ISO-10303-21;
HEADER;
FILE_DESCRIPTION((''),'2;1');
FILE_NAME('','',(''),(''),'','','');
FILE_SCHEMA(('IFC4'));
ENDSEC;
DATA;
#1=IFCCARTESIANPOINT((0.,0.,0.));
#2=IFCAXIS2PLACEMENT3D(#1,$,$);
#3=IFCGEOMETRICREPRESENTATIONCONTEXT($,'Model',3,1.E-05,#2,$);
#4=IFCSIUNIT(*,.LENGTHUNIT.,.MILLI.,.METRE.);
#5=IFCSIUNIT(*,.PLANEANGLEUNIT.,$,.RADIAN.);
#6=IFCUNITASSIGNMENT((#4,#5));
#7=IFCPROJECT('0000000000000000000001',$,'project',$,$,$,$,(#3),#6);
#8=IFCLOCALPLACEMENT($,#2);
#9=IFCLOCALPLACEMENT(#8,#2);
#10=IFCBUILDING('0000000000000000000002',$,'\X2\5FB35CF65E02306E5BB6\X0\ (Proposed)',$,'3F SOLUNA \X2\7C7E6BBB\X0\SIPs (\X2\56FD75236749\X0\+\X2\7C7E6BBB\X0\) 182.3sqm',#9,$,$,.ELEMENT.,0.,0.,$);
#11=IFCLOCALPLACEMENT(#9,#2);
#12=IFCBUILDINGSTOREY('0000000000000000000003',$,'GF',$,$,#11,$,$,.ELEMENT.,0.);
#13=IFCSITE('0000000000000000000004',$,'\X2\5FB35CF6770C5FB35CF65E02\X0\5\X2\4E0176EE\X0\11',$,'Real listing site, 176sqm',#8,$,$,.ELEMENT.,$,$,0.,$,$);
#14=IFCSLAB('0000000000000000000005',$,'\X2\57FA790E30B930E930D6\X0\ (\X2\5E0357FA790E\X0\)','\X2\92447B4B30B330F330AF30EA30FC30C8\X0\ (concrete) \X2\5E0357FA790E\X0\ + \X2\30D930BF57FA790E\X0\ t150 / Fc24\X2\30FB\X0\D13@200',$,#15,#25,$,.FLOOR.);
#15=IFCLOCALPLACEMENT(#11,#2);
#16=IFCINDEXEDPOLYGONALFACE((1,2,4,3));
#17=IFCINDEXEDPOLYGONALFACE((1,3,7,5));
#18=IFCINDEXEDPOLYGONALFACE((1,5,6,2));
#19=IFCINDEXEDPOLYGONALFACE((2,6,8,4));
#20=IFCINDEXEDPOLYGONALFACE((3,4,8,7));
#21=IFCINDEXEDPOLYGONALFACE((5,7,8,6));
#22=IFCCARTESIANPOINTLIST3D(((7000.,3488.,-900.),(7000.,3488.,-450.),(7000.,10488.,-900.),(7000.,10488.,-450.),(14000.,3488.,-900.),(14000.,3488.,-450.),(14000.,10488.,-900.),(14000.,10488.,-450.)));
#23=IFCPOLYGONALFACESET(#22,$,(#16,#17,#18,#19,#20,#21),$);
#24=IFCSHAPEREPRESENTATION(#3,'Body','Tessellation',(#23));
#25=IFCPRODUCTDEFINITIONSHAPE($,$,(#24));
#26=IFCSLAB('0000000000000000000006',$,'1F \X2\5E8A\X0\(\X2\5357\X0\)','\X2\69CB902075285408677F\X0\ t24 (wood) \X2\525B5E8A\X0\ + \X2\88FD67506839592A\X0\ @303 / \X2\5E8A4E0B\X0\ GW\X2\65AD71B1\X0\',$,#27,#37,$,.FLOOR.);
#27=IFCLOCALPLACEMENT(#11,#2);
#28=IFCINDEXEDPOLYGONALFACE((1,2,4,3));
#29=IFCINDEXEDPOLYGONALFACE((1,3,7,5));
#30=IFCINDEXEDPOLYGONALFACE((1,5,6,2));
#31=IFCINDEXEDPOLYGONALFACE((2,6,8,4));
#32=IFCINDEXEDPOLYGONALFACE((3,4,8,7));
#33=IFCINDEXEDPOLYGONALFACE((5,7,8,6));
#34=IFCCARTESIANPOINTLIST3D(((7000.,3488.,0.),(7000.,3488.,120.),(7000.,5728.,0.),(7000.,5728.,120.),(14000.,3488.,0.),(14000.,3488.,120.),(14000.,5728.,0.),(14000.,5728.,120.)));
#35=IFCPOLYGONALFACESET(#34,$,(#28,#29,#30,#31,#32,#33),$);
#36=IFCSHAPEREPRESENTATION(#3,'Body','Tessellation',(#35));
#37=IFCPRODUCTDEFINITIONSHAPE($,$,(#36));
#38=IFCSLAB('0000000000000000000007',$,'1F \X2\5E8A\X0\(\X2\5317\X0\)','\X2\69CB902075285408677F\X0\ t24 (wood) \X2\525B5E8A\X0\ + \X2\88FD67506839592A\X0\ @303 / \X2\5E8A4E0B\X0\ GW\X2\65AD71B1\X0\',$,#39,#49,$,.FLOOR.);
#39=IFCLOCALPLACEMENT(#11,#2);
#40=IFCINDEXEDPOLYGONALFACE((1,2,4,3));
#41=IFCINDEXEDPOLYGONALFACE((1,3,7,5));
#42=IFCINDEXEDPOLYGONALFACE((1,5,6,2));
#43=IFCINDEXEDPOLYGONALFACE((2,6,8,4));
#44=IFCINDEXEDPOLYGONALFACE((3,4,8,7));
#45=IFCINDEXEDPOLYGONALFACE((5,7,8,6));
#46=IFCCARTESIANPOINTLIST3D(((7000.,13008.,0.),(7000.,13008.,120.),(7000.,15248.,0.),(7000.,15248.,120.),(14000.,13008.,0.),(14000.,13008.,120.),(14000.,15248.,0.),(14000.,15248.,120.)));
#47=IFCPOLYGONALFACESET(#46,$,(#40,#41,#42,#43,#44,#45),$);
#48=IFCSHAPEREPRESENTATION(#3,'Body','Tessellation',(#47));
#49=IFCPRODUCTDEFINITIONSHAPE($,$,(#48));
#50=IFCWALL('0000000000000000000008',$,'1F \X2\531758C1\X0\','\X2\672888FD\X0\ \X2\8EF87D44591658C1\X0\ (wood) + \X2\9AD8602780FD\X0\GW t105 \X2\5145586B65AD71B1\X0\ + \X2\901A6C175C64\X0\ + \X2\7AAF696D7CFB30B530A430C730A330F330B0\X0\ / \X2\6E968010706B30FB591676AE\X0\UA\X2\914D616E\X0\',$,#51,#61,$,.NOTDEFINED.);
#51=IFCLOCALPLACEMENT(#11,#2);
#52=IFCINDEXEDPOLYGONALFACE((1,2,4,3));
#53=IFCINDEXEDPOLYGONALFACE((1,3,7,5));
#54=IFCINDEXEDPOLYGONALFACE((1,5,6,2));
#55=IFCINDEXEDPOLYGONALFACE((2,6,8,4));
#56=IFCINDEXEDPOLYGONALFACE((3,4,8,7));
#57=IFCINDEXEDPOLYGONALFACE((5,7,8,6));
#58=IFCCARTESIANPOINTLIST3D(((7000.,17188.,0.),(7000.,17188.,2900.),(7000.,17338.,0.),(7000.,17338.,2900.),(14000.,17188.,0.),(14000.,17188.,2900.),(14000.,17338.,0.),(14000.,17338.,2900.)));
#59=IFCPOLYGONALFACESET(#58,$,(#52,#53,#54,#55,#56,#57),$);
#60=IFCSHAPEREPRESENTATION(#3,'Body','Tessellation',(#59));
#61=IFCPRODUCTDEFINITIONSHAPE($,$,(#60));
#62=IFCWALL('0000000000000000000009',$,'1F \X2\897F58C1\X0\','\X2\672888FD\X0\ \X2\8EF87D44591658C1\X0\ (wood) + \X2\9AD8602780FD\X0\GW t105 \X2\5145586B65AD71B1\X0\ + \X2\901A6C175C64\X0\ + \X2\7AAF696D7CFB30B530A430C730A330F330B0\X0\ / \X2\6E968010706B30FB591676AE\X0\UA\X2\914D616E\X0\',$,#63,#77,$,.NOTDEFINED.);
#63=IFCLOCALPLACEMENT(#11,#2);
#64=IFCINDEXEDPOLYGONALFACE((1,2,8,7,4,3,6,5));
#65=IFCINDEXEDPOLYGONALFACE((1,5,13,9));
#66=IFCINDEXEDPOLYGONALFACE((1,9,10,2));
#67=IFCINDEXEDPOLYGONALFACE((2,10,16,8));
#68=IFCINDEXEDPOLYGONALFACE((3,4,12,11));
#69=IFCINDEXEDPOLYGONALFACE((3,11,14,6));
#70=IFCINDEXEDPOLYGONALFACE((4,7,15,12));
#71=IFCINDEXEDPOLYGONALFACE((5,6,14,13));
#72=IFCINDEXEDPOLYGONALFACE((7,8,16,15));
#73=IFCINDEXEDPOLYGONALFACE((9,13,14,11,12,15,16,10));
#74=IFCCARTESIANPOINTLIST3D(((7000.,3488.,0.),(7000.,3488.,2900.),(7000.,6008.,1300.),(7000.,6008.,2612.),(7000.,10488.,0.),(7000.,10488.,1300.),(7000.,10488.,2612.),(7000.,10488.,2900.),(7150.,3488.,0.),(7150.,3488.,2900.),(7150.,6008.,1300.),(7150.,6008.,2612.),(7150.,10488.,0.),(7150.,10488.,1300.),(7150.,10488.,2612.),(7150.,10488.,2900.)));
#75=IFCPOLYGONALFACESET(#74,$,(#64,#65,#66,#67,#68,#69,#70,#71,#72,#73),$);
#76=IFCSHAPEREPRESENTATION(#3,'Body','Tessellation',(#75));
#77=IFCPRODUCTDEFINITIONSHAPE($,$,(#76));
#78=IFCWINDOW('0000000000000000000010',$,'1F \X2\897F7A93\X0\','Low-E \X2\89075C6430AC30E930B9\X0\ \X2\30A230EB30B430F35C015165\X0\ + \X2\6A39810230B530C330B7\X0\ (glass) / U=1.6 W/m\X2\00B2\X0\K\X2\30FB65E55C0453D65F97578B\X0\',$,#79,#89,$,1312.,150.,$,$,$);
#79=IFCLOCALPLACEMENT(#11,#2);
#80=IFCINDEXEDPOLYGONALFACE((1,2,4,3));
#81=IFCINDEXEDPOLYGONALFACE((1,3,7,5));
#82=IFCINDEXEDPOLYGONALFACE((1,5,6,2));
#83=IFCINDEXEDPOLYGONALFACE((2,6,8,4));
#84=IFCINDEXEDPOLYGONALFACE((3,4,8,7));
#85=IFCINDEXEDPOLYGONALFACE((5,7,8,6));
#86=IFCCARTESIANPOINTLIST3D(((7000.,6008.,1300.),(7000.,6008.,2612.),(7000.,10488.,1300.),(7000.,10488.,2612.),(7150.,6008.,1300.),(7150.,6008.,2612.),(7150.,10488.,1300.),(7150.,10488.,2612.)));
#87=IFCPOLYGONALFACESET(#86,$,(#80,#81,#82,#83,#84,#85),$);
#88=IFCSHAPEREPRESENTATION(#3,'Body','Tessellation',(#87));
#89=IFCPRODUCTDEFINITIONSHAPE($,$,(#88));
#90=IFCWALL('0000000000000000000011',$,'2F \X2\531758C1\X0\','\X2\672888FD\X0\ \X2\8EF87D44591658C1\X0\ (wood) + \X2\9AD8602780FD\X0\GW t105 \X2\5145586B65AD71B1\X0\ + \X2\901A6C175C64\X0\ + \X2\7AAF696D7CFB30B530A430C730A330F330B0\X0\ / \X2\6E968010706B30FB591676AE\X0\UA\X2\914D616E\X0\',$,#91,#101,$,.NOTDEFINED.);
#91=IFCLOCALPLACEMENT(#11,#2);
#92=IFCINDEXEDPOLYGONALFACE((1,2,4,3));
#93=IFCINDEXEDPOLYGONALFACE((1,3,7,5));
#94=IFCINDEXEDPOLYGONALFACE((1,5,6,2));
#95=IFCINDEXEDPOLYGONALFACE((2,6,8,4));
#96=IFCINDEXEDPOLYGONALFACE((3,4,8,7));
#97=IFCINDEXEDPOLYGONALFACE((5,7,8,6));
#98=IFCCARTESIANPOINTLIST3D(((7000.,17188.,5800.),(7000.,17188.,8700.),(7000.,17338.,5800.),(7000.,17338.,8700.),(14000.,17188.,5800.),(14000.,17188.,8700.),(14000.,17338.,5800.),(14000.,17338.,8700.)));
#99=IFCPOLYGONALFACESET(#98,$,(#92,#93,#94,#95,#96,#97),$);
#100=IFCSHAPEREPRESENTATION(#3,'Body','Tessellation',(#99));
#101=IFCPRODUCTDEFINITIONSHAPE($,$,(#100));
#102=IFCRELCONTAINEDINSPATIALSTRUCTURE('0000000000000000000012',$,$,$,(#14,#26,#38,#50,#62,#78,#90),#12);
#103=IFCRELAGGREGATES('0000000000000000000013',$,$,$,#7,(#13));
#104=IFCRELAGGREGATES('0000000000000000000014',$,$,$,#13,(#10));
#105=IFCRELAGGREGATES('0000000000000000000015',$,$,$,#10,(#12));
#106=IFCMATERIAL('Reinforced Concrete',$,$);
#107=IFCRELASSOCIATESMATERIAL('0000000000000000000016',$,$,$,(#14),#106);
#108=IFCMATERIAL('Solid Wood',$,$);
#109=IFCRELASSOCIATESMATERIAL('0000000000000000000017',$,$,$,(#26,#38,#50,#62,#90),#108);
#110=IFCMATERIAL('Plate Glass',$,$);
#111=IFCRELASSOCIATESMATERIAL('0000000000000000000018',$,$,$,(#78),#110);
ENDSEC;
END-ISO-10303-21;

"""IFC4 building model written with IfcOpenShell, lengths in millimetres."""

from ifc_helpers import new_model, si_unit, frame, frame_2d, origin, place, context, project, spatial, rectangle, extrude, material, element, fill, save


model = new_model("IFC4")

# Units and contexts
model_context = context("Model", 3, precision=1e-05, world=origin())
ifc_project = project(units=[si_unit("LENGTHUNIT", "METRE", prefix="MILLI"), si_unit("PLANEANGLEUNIT", "RADIAN")], contexts=[model_context])

# Site, building, storey
site_placement = place(None, origin())
site = spatial("IfcSite", under=ifc_project, at=site_placement, Name="徳島県徳島市5丁目11", ObjectType="Real listing site, 176sqm", CompositionType="ELEMENT", RefElevation=0.0)
building_placement = place(site_placement, origin())
building = spatial("IfcBuilding", under=site, at=building_placement, Name="徳島市の家 (Proposed)", ObjectType="3F SOLUNA 籾殻SIPs (国産杉+籾殻) 182.3sqm", CompositionType="ELEMENT", ElevationOfRefHeight=0.0, ElevationOfTerrain=0.0)
storey_placement = place(building_placement, origin())
storey = spatial("IfcBuildingStorey", under=building, at=storey_placement, Name="GF", CompositionType="ELEMENT", Elevation=0.0)

# Slabs
ifc_material_1 = material(Name="Reinforced Concrete")
slab_1_placement = place(storey_placement, frame((3500.0, 1744.0, -450.0)))
element("IfcSlab", 1, at=slab_1_placement, inside=storey, material=ifc_material_1, Name="基礎スラブ (布基礎)", Description="鉄筋コンクリート (concrete) 布基礎 + ベタ基礎 t150 / Fc24・D13@200", PredefinedType="FLOOR", context=model_context, shape_type="SweptSolid", body=[
    extrude(rectangle(XDim=7000.0, YDim=7000.0, at=frame_2d((3500.0, 3500.0))), frame((3500.0, 1744.0, -450.0)), (0.0, 0.0, 1.0), 450.0),
])
ifc_material_2 = material(Name="Solid Wood")
slab_2_placement = place(storey_placement, frame((3500.0, 1744.0, 0.0)))
element("IfcSlab", 2, at=slab_2_placement, inside=storey, material=ifc_material_2, Name="1F 床(南)", Description="構造用合板 t24 (wood) 剛床 + 製材根太 @303 / 床下 GW断熱", PredefinedType="FLOOR", context=model_context, shape_type="SweptSolid", body=[
    extrude(rectangle(XDim=7000.0, YDim=2240.0, at=frame_2d((3500.0, 1120.0))), frame((3500.0, 1744.0, 0.0)), (0.0, 0.0, 1.0), 120.0),
])
slab_3_placement = place(storey_placement, frame((3500.0, 6504.0, 0.0)))
element("IfcSlab", 3, at=slab_3_placement, inside=storey, material=ifc_material_2, Name="1F 床(北)", Description="構造用合板 t24 (wood) 剛床 + 製材根太 @303 / 床下 GW断熱", PredefinedType="FLOOR", context=model_context, shape_type="SweptSolid", body=[
    extrude(rectangle(XDim=7000.0, YDim=2240.0, at=frame_2d((3500.0, 1120.0))), frame((3500.0, 6504.0, 0.0)), (0.0, 0.0, 1.0), 120.0),
])

# Shared definitions
ifc_material_3 = material(Name="Plate Glass")

# Wall
wall_1_placement = place(storey_placement, frame((3500.0, 8594.0, 0.0)))
element("IfcWall", 4, at=wall_1_placement, inside=storey, material=ifc_material_2, Name="1F 北壁", Description="木製 軸組外壁 (wood) + 高性能GW t105 充填断熱 + 通気層 + 窯業系サイディング / 準耐火・外皮UA配慮", PredefinedType="NOTDEFINED", context=model_context, shape_type="SweptSolid", body=[
    extrude(rectangle(XDim=7000.0, YDim=150.0, at=frame_2d((3500.0, 75.0))), frame((3500.0, 8594.0, 0.0)), (0.0, 0.0, 1.0), 2900.0),
])

# Wall, opening, window
wall_2_placement = place(storey_placement, frame((3500.0, 1744.0, 0.0)))
wall_2 = element("IfcWall", 5, at=wall_2_placement, inside=storey, material=ifc_material_2, Name="1F 西壁", Description="木製 軸組外壁 (wood) + 高性能GW t105 充填断熱 + 通気層 + 窯業系サイディング / 準耐火・外皮UA配慮", PredefinedType="NOTDEFINED", context=model_context, shape_type="SweptSolid", body=[
    extrude(rectangle(XDim=150.0, YDim=7000.0, at=frame_2d((75.0, 3500.0))), frame((3500.0, 1744.0, 0.0)), (0.0, 0.0, 1.0), 2900.0),
])
opening_1_placement = place(storey_placement, frame((3500.0, 3004.0, 650.0)))
opening_1 = element("IfcOpeningElement", 6, at=opening_1_placement, cuts=wall_2, PredefinedType="NOTDEFINED", context=model_context, shape_type="SweptSolid", body=[
    extrude(rectangle(XDim=150.0, YDim=4480.0, at=frame_2d((75.0, 2240.0))), frame((3500.0, 3004.0, 650.0)), (0.0, 0.0, 1.0), 1312.0),
])
window_1_placement = place(storey_placement, frame((3500.0, 3004.0, 650.0)))
window_1 = element("IfcWindow", 7, at=window_1_placement, inside=storey, material=ifc_material_3, Name="1F 西窓", Description="Low-E 複層ガラス アルゴン封入 + 樹脂サッシ (glass) / U=1.6 W/m²K・日射取得型", OverallHeight=1312.0, OverallWidth=150.0, context=model_context, shape_type="SweptSolid", body=[
    extrude(rectangle(XDim=150.0, YDim=4480.0, at=frame_2d((75.0, 2240.0))), frame((3500.0, 3004.0, 650.0)), (0.0, 0.0, 1.0), 1312.0),
])
fill(opening_1, window_1)

# Wall
wall_3_placement = place(storey_placement, frame((3500.0, 8594.0, 2900.0)))
element("IfcWall", 8, at=wall_3_placement, inside=storey, material=ifc_material_2, Name="2F 北壁", Description="木製 軸組外壁 (wood) + 高性能GW t105 充填断熱 + 通気層 + 窯業系サイディング / 準耐火・外皮UA配慮", PredefinedType="NOTDEFINED", context=model_context, shape_type="SweptSolid", body=[
    extrude(rectangle(XDim=7000.0, YDim=150.0, at=frame_2d((3500.0, 75.0))), frame((3500.0, 8594.0, 2900.0)), (0.0, 0.0, 1.0), 2900.0),
])

save(model, "model.ifc")
